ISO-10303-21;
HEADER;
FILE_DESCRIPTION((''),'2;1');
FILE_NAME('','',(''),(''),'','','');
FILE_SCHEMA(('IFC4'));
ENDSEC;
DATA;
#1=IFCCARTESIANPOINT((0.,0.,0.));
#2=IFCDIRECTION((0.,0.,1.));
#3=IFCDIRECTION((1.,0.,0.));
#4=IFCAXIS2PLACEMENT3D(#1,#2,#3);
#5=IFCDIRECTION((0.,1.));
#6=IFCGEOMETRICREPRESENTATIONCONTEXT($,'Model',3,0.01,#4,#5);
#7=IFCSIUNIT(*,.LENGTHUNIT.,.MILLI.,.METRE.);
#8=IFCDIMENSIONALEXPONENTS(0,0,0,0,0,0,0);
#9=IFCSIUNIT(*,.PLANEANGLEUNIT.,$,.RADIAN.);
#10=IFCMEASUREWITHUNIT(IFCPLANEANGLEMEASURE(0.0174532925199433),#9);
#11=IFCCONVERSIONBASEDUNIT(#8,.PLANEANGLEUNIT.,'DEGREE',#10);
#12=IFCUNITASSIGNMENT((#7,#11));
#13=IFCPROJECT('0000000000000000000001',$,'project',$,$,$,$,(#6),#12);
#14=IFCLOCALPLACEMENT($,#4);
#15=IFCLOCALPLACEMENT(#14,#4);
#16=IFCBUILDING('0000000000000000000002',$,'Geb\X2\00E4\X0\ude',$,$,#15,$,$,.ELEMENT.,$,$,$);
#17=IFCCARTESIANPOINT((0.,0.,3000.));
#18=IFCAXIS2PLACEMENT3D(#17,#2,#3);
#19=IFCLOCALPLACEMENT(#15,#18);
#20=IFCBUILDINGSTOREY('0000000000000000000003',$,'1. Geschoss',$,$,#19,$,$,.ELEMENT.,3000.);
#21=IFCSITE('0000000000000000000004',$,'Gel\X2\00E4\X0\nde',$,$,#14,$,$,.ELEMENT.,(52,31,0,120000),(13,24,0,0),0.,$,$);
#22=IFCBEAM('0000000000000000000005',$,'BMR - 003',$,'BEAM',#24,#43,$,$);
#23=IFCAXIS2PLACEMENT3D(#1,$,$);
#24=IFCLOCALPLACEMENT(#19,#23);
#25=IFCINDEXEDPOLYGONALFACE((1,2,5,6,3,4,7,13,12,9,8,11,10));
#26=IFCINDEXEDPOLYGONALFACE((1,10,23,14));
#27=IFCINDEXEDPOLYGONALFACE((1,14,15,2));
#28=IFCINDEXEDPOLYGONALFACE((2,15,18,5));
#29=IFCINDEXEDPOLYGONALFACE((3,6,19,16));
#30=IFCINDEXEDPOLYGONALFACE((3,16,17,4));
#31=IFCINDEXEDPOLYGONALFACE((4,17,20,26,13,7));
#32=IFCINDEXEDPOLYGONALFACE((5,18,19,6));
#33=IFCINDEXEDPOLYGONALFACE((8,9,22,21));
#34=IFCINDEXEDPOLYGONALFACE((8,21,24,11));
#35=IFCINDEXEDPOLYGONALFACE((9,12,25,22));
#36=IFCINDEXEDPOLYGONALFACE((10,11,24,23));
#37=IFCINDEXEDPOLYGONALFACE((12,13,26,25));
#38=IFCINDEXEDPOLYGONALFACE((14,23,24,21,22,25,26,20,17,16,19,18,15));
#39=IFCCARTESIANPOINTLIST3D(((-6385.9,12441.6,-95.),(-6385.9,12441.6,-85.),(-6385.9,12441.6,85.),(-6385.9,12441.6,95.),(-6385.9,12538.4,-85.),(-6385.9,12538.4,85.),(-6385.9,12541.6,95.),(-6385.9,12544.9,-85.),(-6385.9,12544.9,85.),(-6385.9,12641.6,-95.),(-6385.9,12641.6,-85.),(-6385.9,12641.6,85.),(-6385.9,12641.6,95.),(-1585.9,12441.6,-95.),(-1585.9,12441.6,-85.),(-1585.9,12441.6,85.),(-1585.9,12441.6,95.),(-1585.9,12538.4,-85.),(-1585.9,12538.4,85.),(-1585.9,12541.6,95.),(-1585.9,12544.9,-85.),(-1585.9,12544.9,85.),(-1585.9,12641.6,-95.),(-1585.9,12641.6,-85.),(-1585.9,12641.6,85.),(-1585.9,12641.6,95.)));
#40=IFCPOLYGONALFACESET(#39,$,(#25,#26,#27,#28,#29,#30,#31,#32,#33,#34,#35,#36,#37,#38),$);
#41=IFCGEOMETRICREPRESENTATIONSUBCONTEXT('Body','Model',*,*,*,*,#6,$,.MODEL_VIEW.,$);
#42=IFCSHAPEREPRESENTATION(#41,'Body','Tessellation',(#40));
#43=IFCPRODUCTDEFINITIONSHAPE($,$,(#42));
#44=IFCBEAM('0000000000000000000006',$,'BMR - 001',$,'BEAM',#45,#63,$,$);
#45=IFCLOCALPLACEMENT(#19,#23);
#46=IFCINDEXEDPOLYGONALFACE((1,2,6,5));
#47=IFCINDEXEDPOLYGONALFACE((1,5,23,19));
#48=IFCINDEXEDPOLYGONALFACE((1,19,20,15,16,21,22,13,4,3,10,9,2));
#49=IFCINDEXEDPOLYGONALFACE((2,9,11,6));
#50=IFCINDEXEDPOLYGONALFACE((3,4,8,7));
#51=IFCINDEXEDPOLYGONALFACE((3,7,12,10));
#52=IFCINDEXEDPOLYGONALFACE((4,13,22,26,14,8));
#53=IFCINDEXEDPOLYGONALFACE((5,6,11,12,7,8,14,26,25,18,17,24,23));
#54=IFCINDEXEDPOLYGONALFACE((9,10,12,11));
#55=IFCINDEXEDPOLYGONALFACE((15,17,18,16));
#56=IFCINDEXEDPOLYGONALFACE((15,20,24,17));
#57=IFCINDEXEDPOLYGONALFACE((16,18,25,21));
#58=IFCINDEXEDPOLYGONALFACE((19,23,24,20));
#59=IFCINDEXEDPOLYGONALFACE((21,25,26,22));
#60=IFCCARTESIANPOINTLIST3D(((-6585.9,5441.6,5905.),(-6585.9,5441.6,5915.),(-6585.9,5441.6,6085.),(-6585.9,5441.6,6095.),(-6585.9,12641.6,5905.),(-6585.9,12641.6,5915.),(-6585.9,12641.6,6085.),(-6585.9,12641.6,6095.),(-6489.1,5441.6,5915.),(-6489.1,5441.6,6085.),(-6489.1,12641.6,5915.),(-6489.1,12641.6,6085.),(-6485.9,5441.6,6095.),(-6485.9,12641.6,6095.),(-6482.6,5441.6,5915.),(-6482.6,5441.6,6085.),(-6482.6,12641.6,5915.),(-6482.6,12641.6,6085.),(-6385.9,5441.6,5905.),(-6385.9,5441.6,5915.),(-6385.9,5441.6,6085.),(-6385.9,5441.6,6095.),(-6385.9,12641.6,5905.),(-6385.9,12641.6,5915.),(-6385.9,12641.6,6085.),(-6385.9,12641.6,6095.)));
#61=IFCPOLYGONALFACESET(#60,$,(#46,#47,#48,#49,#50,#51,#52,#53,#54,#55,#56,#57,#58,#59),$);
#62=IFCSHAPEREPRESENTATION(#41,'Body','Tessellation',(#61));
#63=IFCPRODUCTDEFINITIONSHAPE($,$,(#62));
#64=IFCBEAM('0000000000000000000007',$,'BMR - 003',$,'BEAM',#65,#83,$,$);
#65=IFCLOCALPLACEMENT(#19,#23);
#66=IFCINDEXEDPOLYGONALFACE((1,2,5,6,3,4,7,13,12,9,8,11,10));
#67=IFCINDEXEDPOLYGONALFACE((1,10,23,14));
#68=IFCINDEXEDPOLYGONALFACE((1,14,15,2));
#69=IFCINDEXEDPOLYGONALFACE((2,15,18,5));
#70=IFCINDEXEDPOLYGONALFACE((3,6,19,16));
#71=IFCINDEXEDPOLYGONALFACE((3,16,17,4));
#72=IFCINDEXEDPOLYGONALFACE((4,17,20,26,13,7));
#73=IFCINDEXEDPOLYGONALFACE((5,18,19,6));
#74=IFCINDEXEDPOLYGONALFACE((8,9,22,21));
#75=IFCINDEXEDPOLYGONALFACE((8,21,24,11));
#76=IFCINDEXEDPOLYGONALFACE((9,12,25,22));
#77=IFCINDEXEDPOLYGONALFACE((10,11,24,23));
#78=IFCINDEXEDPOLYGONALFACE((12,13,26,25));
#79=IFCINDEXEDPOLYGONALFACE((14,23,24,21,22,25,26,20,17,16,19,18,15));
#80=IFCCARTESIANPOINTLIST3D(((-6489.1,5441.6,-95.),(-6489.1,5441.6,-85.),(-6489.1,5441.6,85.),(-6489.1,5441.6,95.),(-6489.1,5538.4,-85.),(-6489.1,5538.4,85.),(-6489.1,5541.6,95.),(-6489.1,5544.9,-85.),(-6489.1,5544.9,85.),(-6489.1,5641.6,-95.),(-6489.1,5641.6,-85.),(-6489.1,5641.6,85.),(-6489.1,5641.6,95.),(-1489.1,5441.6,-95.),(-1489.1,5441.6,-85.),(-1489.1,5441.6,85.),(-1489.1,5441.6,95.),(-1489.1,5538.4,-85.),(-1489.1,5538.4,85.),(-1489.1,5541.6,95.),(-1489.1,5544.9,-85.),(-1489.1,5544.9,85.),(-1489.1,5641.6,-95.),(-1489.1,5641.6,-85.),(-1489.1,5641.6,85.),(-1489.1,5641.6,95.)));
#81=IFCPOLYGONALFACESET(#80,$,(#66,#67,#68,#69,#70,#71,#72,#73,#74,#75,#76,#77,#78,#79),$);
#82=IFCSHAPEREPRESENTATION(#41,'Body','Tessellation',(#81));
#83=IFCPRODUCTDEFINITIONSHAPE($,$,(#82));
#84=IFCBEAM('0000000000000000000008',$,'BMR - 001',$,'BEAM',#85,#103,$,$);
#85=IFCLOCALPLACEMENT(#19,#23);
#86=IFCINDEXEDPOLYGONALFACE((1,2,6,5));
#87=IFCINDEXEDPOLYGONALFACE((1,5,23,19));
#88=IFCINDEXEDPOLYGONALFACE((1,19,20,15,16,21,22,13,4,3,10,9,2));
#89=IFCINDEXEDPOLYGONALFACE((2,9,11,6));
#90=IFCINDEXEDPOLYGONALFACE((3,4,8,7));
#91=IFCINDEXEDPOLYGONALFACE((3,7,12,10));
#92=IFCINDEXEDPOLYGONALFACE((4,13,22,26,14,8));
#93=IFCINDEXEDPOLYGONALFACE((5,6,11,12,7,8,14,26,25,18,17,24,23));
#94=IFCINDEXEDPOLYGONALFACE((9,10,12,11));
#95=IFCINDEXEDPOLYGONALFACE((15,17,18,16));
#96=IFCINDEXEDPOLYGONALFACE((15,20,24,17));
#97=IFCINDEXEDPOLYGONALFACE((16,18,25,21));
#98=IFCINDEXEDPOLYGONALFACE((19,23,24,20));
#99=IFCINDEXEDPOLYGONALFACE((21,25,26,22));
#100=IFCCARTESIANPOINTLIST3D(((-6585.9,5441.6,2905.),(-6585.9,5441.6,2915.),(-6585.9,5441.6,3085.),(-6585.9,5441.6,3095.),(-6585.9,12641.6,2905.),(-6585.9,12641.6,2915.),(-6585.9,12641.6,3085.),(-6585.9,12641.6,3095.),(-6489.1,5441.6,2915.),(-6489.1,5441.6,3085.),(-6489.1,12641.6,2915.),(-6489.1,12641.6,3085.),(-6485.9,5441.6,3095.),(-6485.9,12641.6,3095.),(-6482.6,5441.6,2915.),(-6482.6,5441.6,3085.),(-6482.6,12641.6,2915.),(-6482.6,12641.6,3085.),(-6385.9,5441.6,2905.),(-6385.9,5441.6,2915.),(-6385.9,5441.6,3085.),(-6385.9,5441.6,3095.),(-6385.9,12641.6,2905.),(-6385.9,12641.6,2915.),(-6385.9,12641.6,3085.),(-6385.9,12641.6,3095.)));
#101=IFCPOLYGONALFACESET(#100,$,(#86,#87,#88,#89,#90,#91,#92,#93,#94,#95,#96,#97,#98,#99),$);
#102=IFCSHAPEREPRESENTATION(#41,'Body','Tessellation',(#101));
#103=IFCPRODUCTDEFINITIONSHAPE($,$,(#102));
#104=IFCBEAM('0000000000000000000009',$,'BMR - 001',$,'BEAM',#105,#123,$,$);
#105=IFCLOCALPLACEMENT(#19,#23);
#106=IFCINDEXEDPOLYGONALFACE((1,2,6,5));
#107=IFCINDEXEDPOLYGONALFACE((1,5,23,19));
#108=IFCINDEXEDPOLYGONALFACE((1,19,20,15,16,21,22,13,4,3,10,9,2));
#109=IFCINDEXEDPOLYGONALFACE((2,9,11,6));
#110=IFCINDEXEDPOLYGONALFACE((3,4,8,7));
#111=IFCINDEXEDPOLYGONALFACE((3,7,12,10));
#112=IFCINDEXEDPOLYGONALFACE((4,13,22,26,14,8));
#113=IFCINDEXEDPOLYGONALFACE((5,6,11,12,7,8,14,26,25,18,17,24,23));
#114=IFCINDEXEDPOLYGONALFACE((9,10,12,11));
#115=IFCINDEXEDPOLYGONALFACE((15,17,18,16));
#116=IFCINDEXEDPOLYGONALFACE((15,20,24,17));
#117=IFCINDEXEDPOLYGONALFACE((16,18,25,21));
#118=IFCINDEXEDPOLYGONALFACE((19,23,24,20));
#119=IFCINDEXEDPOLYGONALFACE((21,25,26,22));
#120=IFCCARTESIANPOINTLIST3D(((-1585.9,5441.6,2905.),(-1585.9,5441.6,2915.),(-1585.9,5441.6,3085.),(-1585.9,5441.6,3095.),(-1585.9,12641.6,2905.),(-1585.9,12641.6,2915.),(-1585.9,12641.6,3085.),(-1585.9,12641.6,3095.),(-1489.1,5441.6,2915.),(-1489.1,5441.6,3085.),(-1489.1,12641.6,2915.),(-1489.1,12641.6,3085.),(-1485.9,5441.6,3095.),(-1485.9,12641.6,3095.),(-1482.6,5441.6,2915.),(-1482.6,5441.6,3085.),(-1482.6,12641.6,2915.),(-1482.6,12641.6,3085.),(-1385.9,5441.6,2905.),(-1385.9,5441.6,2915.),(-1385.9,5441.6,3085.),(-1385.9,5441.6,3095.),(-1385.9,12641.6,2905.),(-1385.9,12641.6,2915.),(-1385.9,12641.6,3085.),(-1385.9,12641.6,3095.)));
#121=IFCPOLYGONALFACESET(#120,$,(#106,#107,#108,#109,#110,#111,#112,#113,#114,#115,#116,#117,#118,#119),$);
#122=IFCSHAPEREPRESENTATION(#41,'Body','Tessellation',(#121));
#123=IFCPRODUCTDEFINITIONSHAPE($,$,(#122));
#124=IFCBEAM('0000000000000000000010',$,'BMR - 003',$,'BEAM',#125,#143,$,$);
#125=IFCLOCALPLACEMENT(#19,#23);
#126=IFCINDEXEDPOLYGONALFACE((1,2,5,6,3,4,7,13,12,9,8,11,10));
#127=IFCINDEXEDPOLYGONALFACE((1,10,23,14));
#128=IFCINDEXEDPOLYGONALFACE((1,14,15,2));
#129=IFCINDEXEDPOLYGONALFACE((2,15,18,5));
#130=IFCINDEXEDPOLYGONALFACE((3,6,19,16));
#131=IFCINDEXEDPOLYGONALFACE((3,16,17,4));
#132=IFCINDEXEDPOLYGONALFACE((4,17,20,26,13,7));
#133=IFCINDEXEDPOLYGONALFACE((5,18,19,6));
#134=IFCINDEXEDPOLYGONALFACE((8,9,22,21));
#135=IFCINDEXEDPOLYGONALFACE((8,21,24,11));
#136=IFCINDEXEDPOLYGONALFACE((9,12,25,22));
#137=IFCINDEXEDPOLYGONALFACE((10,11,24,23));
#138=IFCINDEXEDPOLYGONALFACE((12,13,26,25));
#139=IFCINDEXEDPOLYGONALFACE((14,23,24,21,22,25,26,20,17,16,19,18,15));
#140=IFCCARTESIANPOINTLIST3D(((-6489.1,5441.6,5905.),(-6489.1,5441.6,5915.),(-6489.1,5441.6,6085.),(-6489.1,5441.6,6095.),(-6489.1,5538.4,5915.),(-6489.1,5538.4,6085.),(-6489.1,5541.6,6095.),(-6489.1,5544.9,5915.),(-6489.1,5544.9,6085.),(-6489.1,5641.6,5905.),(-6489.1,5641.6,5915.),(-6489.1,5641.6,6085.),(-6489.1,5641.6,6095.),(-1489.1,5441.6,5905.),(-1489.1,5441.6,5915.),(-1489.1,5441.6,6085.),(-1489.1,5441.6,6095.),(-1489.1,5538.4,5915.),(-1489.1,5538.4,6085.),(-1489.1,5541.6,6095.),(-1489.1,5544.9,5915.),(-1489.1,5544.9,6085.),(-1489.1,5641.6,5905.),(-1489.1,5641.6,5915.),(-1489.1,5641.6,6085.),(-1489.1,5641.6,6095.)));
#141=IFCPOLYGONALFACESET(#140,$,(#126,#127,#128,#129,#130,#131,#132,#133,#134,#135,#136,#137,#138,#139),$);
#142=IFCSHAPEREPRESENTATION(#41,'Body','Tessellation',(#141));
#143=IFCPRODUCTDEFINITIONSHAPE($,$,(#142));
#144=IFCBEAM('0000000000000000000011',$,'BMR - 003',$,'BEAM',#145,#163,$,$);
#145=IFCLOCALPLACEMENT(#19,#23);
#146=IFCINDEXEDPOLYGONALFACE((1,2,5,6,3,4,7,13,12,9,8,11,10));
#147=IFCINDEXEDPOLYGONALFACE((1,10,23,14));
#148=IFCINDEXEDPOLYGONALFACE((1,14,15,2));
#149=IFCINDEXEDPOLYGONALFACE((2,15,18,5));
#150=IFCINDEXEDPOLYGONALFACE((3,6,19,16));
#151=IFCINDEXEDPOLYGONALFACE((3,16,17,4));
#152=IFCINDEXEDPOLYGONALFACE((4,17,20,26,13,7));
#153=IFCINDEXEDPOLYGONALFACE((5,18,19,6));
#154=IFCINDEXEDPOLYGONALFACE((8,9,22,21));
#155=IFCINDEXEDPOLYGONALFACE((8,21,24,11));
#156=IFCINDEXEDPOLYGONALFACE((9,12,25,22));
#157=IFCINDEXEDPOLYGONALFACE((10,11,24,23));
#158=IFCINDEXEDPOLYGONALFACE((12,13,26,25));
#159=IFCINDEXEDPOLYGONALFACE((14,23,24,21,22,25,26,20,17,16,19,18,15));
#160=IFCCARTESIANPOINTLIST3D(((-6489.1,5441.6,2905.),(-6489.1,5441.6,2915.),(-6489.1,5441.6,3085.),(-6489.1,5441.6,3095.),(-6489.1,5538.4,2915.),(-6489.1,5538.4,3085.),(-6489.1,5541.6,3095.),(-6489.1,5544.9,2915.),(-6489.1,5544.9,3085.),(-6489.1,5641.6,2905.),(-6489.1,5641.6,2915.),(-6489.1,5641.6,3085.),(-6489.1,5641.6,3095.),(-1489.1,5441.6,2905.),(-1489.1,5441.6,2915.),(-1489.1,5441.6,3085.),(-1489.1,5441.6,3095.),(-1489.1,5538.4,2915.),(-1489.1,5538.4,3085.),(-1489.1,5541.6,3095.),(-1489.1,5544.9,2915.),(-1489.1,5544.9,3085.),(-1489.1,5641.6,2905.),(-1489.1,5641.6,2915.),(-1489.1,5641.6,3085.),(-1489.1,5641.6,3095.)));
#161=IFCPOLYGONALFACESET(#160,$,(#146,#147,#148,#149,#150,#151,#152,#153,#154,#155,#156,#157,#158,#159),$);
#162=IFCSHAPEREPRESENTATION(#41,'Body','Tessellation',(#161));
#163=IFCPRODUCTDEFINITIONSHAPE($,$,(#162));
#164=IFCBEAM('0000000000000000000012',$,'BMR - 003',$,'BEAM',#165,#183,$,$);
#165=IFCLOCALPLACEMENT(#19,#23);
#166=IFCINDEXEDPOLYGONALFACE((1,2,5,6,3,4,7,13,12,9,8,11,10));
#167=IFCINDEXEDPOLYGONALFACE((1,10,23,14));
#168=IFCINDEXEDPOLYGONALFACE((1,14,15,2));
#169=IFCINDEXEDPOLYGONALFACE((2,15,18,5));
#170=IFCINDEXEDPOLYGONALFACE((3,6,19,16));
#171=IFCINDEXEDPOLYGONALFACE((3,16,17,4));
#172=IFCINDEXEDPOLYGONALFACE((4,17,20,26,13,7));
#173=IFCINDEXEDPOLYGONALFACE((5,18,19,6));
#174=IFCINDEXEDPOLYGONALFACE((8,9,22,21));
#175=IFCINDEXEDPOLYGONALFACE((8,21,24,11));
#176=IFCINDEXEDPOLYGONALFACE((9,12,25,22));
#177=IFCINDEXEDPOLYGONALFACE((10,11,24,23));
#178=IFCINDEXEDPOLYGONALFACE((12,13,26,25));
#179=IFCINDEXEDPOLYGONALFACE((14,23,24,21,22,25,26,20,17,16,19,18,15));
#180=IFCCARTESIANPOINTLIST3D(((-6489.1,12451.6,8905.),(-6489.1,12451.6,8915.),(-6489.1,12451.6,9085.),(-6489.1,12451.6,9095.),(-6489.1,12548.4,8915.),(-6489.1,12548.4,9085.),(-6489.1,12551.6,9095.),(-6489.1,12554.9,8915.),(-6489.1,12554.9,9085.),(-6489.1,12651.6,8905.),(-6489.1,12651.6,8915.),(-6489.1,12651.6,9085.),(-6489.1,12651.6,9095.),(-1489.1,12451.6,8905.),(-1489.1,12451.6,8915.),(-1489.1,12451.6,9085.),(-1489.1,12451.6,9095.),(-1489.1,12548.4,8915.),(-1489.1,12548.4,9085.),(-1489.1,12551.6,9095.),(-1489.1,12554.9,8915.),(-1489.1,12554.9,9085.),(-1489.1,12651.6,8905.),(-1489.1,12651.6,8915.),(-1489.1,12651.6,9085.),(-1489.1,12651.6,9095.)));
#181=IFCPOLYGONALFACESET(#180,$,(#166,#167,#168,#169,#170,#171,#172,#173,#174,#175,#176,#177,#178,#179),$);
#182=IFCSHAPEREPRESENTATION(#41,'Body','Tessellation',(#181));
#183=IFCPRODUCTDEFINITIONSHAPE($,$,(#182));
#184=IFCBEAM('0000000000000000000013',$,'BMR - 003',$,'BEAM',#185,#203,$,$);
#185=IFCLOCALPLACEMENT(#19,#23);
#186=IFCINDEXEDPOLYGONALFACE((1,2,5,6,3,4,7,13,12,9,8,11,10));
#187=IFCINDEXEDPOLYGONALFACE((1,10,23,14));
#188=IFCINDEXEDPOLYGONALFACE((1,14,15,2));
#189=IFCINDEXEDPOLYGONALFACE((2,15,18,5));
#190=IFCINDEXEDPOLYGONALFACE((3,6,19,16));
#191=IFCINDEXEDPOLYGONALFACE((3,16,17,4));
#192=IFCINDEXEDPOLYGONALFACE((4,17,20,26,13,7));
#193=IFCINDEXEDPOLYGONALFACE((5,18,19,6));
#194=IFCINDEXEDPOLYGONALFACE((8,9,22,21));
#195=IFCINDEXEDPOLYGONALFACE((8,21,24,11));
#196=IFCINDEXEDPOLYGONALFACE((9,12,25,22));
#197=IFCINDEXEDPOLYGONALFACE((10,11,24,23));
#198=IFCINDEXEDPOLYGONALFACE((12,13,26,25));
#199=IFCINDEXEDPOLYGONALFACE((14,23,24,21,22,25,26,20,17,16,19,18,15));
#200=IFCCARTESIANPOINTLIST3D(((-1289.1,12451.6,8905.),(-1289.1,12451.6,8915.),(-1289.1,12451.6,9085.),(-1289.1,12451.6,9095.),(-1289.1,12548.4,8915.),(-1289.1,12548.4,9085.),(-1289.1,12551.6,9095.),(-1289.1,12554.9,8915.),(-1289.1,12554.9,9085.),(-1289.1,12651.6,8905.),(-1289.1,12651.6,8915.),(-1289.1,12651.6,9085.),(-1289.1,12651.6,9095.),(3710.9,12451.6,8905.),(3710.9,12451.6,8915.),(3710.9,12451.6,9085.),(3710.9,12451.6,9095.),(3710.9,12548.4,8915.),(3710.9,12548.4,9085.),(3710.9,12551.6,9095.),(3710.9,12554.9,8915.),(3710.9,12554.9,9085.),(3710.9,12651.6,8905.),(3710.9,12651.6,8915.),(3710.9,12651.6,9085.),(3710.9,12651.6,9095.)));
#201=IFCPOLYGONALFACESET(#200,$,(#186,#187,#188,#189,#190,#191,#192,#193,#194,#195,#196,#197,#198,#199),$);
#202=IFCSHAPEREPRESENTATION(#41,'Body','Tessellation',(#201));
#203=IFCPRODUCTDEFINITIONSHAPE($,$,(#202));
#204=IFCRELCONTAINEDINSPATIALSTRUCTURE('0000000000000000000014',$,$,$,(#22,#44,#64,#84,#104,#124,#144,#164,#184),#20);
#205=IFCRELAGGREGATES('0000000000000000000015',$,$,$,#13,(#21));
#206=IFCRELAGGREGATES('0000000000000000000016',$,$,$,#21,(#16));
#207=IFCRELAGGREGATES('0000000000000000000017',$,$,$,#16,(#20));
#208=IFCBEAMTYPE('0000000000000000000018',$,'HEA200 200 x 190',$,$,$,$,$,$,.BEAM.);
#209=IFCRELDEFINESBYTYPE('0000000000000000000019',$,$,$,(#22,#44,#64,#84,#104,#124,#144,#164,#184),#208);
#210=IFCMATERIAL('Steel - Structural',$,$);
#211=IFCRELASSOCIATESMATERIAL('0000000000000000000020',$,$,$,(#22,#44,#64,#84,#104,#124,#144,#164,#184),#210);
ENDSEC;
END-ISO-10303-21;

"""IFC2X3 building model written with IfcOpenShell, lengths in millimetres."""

from ifc_helpers import new_model, entity, si_unit, converted_unit, direction, frame, origin_with_axes, place, context, subcontext, project, spatial, polyline, outline, extrude, material, type_object, element, save


model = new_model("IFC2X3")

# Units and contexts
model_context = context("Model", 3, precision=0.01, world=origin_with_axes(), true_north=direction((0.0, 1.0)))
body_context = subcontext(model_context, "Body", "Model", "MODEL_VIEW")
ifc_project = project(units=[si_unit("LENGTHUNIT", "METRE", prefix="MILLI"), converted_unit("PLANEANGLEUNIT", "DEGREE", entity("IfcPlaneAngleMeasure", 0.0174532925199433), si_unit("PLANEANGLEUNIT", "RADIAN"), dimensions=[0, 0, 0, 0, 0, 0, 0])], contexts=[model_context])

# Site, building, storey
site_placement = place(None, origin_with_axes())
site = spatial("IfcSite", under=ifc_project, at=site_placement, Name="Gelände", CompositionType="ELEMENT", RefLatitude=(52, 31, 0, 120000), RefLongitude=(13, 24, 0, 0), RefElevation=0.0)
building_placement = place(site_placement, origin_with_axes())
building = spatial("IfcBuilding", under=site, at=building_placement, Name="Gebäude", CompositionType="ELEMENT")
storey_placement = place(building_placement, frame((0.0, 0.0, 3000.0), z_axis=(0.0, 0.0, 1.0), x_axis=(1.0, 0.0, 0.0)))
storey = spatial("IfcBuildingStorey", under=building, at=storey_placement, Name="1. Geschoss", CompositionType="ELEMENT", Elevation=3000.0)

# Beams
ifc_material = material(Name="Steel - Structural")
beam_type = type_object("IfcBeamType", Name="HEA200 200 x 190", PredefinedType="BEAM")
beam_1_placement = place(storey_placement, frame((-6385.9, 12541.6, 0.0), z_axis=(0.0, 0.0, 1.0), x_axis=(0.0, -1.0, 0.0)))
element("IfcBeam", 1, at=beam_1_placement, inside=storey, type_object=beam_type, material=ifc_material, Name="BMR - 003", ObjectType="BEAM", context=body_context, shape_type="SweptSolid", body=[
    extrude(outline(polyline([(0.0, 95.0), (-100.0, 95.0), (-100.0, 85.0), (-3.2, 85.0), (-3.2, -85.0), (-100.0, -85.0), (-100.0, -95.0), (100.0, -95.0), (100.0, -85.0), (3.2, -85.0), (3.2, 85.0), (100.0, 85.0), (100.0, 95.0), (0.0, 95.0)])), frame((0.0, 4800.0, 0.0), z_axis=(0.0, -1.0, 0.0), x_axis=(1.0, 0.0, 0.0)), (0.0, 0.0, 1.0), 4800.0),
])
beam_2_placement = place(storey_placement, frame((-6485.9, 5441.6, 6000.0), z_axis=(0.0, 0.0, 1.0), x_axis=(1.0, 0.0, 0.0)))
element("IfcBeam", 2, at=beam_2_placement, inside=storey, type_object=beam_type, material=ifc_material, Name="BMR - 001", ObjectType="BEAM", context=body_context, shape_type="SweptSolid", body=[
    extrude(outline(polyline([(0.0, 95.0), (-100.0, 95.0), (-100.0, 85.0), (-3.2, 85.0), (-3.2, -85.0), (-100.0, -85.0), (-100.0, -95.0), (100.0, -95.0), (100.0, -85.0), (3.2, -85.0), (3.2, 85.0), (100.0, 85.0), (100.0, 95.0), (0.0, 95.0)])), frame((0.0, 7200.0, 0.0), z_axis=(0.0, -1.0, 0.0), x_axis=(1.0, 0.0, 0.0)), (0.0, 0.0, 1.0), 7200.0),
])
beam_3_placement = place(storey_placement, frame((-6489.1, 5541.6, 0.0), z_axis=(0.0, 0.0, 1.0), x_axis=(0.0, -1.0, 0.0)))
element("IfcBeam", 3, at=beam_3_placement, inside=storey, type_object=beam_type, material=ifc_material, Name="BMR - 003", ObjectType="BEAM", context=body_context, shape_type="SweptSolid", body=[
    extrude(outline(polyline([(0.0, 95.0), (-100.0, 95.0), (-100.0, 85.0), (-3.2, 85.0), (-3.2, -85.0), (-100.0, -85.0), (-100.0, -95.0), (100.0, -95.0), (100.0, -85.0), (3.2, -85.0), (3.2, 85.0), (100.0, 85.0), (100.0, 95.0), (0.0, 95.0)])), frame((0.0, 5000.0, 0.0), z_axis=(0.0, -1.0, 0.0), x_axis=(1.0, 0.0, 0.0)), (0.0, 0.0, 1.0), 5000.0),
])
for number, where, z_axis, x_axis, name in (
    (4, (-6485.9, 5441.6, 3000.0), (0.0, 0.0, 1.0), (1.0, 0.0, 0.0), "BMR - 001"),
    (5, (-1485.9, 5441.6, 3000.0), (0.0, 0.0, 1.0), (1.0, 0.0, 0.0), "BMR - 001"),
):
    element("IfcBeam", number, at=place(storey_placement, frame(where, z_axis=z_axis, x_axis=x_axis)), inside=storey, type_object=beam_type, material=ifc_material, Name=name, ObjectType="BEAM", context=body_context, shape_type="SweptSolid", body=[
        extrude(outline(polyline([(0.0, 95.0), (-100.0, 95.0), (-100.0, 85.0), (-3.2, 85.0), (-3.2, -85.0), (-100.0, -85.0), (-100.0, -95.0), (100.0, -95.0), (100.0, -85.0), (3.2, -85.0), (3.2, 85.0), (100.0, 85.0), (100.0, 95.0), (0.0, 95.0)])), frame((0.0, 7200.0, 0.0), z_axis=(0.0, -1.0, 0.0), x_axis=(1.0, 0.0, 0.0)), (0.0, 0.0, 1.0), 7200.0),
    ])
for number, where, z_axis, x_axis, name in (
    (6, (-6489.1, 5541.6, 6000.0), (0.0, 0.0, 1.0), (0.0, -1.0, 0.0), "BMR - 003"),
    (7, (-6489.1, 5541.6, 3000.0), (0.0, 0.0, 1.0), (0.0, -1.0, 0.0), "BMR - 003"),
    (8, (-6489.1, 12551.6, 9000.0), (0.0, 0.0, 1.0), (0.0, -1.0, 0.0), "BMR - 003"),
    (9, (-1289.1, 12551.6, 9000.0), (0.0, 0.0, 1.0), (0.0, -1.0, 0.0), "BMR - 003"),
):
    element("IfcBeam", number, at=place(storey_placement, frame(where, z_axis=z_axis, x_axis=x_axis)), inside=storey, type_object=beam_type, material=ifc_material, Name=name, ObjectType="BEAM", context=body_context, shape_type="SweptSolid", body=[
        extrude(outline(polyline([(0.0, 95.0), (-100.0, 95.0), (-100.0, 85.0), (-3.2, 85.0), (-3.2, -85.0), (-100.0, -85.0), (-100.0, -95.0), (100.0, -95.0), (100.0, -85.0), (3.2, -85.0), (3.2, 85.0), (100.0, 85.0), (100.0, 95.0), (0.0, 95.0)])), frame((0.0, 5000.0, 0.0), z_axis=(0.0, -1.0, 0.0), x_axis=(1.0, 0.0, 0.0)), (0.0, 0.0, 1.0), 5000.0),
    ])

save(model, "model.ifc")
